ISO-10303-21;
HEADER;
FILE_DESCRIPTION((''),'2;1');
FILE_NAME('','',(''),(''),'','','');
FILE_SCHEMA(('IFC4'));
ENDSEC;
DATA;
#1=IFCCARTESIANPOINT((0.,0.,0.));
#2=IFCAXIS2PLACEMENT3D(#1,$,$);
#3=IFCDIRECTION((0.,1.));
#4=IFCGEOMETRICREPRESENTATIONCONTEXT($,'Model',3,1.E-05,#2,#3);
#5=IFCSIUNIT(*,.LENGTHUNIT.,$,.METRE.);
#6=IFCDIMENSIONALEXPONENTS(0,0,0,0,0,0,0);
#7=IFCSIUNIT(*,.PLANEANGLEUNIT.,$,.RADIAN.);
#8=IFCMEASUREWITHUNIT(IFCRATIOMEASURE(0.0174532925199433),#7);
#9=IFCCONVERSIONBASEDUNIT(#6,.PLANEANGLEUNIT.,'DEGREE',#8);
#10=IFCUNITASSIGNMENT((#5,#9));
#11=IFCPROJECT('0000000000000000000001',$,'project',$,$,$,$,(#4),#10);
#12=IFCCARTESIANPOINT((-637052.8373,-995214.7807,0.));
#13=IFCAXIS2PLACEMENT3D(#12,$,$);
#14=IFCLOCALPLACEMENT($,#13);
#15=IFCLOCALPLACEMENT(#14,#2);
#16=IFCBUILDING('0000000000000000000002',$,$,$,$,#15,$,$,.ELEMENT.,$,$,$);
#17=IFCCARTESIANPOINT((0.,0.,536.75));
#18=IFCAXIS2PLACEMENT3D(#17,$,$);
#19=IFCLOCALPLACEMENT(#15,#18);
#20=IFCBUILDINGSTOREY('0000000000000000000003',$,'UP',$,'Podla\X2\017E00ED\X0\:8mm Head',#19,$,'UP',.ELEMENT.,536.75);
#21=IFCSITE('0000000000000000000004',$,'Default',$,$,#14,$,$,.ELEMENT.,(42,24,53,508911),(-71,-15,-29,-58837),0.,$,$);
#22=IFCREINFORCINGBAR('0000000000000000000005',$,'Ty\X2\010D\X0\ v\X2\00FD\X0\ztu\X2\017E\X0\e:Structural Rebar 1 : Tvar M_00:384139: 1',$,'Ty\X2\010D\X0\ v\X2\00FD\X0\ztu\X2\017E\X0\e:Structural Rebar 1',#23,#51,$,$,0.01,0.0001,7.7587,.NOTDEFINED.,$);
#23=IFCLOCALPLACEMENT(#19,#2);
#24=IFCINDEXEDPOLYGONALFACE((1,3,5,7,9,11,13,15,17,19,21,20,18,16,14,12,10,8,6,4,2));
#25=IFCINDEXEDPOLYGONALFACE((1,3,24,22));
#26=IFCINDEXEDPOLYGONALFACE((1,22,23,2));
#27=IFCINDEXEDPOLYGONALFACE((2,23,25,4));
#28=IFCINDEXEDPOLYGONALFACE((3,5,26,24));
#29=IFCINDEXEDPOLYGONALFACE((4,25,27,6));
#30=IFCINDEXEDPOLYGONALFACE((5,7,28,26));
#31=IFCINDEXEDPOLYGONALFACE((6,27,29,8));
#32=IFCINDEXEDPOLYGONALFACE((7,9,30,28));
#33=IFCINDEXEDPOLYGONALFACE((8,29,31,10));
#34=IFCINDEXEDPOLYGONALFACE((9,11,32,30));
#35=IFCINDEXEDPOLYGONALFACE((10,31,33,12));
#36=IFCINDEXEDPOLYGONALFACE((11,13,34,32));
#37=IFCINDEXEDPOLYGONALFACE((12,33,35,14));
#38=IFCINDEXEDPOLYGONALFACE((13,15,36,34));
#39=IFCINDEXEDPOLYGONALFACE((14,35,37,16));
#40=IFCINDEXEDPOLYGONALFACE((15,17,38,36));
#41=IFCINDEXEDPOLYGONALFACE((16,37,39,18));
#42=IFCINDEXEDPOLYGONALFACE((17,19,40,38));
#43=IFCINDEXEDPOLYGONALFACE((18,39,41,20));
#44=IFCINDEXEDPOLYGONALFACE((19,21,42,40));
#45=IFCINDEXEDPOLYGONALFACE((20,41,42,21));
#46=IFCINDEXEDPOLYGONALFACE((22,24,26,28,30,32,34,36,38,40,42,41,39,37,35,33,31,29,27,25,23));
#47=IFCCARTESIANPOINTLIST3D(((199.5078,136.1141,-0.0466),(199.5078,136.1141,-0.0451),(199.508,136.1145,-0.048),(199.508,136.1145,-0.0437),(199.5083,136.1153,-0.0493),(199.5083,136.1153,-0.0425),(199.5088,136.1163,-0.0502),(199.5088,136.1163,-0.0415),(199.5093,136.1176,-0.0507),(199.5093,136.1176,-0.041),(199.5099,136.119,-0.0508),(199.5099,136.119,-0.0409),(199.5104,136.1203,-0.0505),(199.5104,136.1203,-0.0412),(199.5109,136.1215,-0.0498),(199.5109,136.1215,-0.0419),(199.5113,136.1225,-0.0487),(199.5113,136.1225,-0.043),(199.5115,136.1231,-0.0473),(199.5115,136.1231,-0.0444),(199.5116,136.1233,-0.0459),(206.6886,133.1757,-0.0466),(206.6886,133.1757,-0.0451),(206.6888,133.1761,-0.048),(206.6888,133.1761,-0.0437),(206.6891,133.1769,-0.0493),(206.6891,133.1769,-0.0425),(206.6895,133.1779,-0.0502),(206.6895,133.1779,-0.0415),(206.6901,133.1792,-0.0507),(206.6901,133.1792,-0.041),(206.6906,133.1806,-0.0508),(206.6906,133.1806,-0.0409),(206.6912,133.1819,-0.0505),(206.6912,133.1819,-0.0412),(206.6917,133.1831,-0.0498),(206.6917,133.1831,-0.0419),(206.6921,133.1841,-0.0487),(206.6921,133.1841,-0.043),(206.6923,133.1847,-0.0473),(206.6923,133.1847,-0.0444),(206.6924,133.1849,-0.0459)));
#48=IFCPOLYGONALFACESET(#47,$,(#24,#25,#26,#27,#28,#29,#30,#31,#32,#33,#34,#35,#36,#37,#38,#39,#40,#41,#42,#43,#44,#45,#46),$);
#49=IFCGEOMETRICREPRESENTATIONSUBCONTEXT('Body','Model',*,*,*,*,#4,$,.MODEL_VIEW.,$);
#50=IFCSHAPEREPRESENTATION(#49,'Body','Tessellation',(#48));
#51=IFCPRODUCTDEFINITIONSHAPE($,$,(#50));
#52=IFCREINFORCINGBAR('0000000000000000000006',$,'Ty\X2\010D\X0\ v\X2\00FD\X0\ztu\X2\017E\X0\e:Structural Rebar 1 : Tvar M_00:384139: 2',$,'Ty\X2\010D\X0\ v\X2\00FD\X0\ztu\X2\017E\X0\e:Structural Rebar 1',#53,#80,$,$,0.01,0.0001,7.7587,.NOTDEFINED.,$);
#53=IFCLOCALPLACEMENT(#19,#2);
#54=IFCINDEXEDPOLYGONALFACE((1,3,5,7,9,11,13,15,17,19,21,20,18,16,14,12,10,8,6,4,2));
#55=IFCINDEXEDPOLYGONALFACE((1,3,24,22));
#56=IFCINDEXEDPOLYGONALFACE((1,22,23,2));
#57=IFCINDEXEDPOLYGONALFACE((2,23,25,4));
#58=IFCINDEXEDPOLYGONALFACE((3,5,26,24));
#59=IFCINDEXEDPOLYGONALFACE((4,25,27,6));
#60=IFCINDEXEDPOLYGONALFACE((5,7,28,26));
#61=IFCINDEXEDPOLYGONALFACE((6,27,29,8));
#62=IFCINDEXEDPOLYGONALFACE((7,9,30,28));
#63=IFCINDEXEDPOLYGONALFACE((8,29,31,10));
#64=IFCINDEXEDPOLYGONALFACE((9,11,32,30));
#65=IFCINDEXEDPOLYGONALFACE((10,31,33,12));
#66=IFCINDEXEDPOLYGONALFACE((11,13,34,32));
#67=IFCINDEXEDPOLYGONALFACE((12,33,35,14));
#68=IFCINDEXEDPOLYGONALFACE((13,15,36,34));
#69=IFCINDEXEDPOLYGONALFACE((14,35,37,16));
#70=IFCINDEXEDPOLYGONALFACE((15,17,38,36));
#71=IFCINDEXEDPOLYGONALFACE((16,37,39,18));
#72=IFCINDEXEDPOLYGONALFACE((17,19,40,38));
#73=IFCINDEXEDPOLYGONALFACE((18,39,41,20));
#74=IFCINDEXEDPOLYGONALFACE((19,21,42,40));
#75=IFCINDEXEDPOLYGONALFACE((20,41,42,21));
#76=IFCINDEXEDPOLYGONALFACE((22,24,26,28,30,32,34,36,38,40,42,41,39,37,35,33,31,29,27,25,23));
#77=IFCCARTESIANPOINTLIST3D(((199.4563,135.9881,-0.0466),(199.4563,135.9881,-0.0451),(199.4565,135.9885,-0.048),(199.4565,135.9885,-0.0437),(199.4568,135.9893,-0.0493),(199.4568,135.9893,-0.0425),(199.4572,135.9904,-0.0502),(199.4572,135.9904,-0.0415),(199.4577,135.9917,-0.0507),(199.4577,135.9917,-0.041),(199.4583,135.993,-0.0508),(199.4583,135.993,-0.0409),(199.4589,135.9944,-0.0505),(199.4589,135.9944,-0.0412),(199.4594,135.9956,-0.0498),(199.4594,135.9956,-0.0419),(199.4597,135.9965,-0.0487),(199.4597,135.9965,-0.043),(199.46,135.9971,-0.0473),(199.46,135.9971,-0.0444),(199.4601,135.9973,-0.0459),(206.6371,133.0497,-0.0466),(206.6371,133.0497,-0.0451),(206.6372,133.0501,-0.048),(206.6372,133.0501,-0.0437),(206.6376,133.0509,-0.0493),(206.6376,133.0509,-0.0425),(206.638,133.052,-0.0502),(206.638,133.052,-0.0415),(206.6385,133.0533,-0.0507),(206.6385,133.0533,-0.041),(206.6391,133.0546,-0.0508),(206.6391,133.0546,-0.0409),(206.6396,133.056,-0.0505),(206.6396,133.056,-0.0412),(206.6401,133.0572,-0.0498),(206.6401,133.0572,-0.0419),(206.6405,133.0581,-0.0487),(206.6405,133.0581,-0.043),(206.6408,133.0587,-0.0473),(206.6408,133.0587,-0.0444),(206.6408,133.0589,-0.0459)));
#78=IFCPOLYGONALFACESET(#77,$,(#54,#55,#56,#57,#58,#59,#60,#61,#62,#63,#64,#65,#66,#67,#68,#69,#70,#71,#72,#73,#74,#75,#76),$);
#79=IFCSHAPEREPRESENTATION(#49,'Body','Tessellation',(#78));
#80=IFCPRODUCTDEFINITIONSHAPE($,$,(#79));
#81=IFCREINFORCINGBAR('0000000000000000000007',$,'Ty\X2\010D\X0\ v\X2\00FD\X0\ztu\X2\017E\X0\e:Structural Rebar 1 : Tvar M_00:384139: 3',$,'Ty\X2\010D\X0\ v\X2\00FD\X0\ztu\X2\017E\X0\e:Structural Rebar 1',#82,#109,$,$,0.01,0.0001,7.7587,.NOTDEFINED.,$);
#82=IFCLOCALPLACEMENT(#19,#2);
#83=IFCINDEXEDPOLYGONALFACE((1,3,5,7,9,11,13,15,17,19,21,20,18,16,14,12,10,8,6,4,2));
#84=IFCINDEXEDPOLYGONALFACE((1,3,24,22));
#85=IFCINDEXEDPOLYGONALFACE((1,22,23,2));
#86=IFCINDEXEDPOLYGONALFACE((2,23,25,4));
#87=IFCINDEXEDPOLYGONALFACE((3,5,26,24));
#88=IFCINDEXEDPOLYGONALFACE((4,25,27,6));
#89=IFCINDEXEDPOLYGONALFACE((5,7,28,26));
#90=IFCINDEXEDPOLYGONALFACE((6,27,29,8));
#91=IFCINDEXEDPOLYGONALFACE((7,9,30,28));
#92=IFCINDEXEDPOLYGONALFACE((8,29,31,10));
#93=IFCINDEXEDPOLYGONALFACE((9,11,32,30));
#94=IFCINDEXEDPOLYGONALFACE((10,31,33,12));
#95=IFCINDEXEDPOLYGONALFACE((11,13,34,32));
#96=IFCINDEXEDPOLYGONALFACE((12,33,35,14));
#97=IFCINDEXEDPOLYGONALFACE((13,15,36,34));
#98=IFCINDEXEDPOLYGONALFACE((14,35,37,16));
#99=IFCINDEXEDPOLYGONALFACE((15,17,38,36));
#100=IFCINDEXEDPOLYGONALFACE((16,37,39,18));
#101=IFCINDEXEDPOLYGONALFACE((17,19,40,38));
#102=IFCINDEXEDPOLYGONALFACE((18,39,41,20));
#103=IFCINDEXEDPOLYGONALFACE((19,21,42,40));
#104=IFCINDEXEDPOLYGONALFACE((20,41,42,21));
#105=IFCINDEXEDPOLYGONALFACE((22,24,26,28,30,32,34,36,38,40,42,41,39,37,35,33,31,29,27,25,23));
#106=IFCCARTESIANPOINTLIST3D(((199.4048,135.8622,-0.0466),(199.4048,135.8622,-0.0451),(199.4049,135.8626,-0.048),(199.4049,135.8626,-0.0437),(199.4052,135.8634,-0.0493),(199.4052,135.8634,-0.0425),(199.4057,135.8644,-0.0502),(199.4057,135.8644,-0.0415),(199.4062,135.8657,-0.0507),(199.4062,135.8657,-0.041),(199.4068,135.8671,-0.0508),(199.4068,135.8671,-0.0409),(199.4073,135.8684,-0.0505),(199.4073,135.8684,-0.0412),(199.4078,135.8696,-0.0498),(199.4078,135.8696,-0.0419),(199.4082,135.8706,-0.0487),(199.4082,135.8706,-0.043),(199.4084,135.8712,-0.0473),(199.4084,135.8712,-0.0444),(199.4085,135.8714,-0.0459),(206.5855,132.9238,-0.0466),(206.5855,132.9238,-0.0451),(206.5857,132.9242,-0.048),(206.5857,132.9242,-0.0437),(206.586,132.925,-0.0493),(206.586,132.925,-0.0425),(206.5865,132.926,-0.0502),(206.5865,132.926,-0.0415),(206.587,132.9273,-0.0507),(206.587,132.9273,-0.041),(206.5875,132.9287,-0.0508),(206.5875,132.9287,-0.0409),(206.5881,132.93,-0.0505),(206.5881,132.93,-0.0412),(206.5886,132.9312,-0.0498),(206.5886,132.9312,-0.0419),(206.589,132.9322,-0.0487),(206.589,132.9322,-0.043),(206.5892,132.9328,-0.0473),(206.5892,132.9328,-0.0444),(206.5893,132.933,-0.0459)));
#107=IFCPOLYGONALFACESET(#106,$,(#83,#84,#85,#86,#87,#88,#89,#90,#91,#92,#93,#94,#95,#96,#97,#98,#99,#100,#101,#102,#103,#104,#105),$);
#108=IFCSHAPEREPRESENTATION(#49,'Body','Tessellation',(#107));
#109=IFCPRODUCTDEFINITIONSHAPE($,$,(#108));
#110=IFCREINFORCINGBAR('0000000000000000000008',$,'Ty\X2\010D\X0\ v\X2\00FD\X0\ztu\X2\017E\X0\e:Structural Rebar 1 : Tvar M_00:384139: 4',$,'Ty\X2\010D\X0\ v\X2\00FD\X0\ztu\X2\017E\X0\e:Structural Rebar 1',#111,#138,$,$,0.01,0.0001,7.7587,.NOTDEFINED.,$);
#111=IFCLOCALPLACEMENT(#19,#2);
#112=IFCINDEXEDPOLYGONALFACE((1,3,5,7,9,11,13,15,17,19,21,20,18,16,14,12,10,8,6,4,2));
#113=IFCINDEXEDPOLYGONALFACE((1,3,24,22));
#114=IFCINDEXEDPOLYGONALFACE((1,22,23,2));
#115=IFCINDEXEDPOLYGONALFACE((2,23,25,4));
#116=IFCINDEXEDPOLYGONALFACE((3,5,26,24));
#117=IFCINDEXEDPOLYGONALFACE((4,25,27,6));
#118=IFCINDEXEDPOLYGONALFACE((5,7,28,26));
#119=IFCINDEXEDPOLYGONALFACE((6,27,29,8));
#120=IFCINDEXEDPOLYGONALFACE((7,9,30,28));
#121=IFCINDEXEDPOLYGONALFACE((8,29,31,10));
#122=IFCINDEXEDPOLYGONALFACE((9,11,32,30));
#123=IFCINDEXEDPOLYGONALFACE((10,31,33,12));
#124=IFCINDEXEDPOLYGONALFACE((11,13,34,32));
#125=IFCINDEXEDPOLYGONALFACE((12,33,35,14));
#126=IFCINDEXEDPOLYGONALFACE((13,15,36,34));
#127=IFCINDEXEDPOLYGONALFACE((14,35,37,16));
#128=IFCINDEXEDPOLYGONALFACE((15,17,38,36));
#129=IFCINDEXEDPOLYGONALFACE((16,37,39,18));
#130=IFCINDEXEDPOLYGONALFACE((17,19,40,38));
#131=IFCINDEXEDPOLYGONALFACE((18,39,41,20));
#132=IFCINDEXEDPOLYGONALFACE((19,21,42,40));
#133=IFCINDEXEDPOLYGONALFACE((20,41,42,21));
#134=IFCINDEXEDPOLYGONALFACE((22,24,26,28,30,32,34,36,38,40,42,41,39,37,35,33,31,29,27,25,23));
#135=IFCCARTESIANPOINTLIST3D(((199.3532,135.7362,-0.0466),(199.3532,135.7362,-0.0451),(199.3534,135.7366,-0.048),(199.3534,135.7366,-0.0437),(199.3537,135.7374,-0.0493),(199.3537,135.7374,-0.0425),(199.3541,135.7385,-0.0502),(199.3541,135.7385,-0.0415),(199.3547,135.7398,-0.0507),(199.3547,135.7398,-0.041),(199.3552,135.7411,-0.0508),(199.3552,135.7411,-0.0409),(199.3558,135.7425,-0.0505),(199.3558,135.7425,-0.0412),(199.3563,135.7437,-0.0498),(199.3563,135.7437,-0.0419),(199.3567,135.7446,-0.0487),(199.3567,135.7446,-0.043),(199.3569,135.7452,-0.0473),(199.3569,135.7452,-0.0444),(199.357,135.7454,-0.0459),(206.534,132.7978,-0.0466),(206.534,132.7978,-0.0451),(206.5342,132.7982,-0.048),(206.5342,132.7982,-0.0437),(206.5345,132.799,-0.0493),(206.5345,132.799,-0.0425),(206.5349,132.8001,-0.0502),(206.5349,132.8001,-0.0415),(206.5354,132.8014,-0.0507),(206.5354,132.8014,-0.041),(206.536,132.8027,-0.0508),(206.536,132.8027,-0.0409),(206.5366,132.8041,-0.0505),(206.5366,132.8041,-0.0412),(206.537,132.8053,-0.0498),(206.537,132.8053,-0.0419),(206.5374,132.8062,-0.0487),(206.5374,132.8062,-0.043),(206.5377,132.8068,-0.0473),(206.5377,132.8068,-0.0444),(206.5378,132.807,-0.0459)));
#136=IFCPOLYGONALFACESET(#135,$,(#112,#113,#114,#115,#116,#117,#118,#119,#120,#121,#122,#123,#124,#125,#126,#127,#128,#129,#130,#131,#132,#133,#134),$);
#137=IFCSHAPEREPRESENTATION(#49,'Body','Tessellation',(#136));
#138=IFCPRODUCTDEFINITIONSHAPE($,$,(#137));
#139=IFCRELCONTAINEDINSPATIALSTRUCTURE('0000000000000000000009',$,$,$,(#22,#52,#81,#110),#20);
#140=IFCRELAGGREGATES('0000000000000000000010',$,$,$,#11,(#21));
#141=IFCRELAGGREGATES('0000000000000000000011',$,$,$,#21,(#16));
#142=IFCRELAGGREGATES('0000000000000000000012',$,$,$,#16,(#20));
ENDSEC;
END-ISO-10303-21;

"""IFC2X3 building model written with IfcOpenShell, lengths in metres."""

from ifc_helpers import new_model, entity, si_unit, converted_unit, direction, frame, origin, place, context, subcontext, project, spatial, element, save


model = new_model("IFC2X3")

# Units and contexts
model_context = context("Model", 3, precision=1e-05, world=origin(), true_north=direction((0.0, 1.0)))
body_context = subcontext(model_context, "Body", "Model", "MODEL_VIEW")
ifc_project = project(units=[si_unit("LENGTHUNIT", "METRE"), converted_unit("PLANEANGLEUNIT", "DEGREE", entity("IfcRatioMeasure", 0.0174532925199433), si_unit("PLANEANGLEUNIT", "RADIAN"), dimensions=[0, 0, 0, 0, 0, 0, 0])], contexts=[model_context])

# Site, building, storey
site_placement = place(None, frame((-637052.8373, -995214.7807, 0.0)))
site = spatial("IfcSite", under=ifc_project, at=site_placement, Name="Default", CompositionType="ELEMENT", RefLatitude=(42, 24, 53, 508911), RefLongitude=(-71, -15, -29, -58837), RefElevation=0.0)
building_placement = place(site_placement, origin())
building = spatial("IfcBuilding", under=site, at=building_placement, CompositionType="ELEMENT")
storey_placement = place(building_placement, frame((0.0, 0.0, 536.75)))
storey = spatial("IfcBuildingStorey", under=building, at=storey_placement, Name="UP", ObjectType="Podlaží:8mm Head", LongName="UP", CompositionType="ELEMENT", Elevation=536.75)

# Reinforcing bars
reinforcing_bar_1_placement = place(storey_placement, origin())
element("IfcReinforcingBar", 1, at=reinforcing_bar_1_placement, inside=storey, Name="Tyč výztuže:Structural Rebar 1 : Tvar M_00:384139: 1", ObjectType="Tyč výztuže:Structural Rebar 1", BarLength=7.7587, BarRole="NOTDEFINED", CrossSectionArea=0.0001, NominalDiameter=0.01, context=body_context, shape_type="AdvancedSweptSolid", body=[
    entity("IfcSweptDiskSolid", entity("IfcCompositeCurve", [entity("IfcCompositeCurveSegment", "CONTINUOUS", True, entity("IfcPolyline", [entity("IfcCartesianPoint", [-206.6905, -133.1803, 0.0459]), entity("IfcCartesianPoint", [-199.5097, -136.1187, 0.0459])]))], False), 0.005, None, 0.0, 1.0),
])
reinforcing_bar_2_placement = place(storey_placement, origin())
element("IfcReinforcingBar", 2, at=reinforcing_bar_2_placement, inside=storey, Name="Tyč výztuže:Structural Rebar 1 : Tvar M_00:384139: 2", ObjectType="Tyč výztuže:Structural Rebar 1", BarLength=7.7587, BarRole="NOTDEFINED", CrossSectionArea=0.0001, NominalDiameter=0.01, context=body_context, shape_type="AdvancedSweptSolid", body=[
    entity("IfcSweptDiskSolid", entity("IfcCompositeCurve", [entity("IfcCompositeCurveSegment", "CONTINUOUS", True, entity("IfcPolyline", [entity("IfcCartesianPoint", [-206.6389, -133.0543, 0.0459]), entity("IfcCartesianPoint", [-199.4582, -135.9927, 0.0459])]))], False), 0.005, None, 0.0, 1.0),
])
reinforcing_bar_3_placement = place(storey_placement, origin())
element("IfcReinforcingBar", 3, at=reinforcing_bar_3_placement, inside=storey, Name="Tyč výztuže:Structural Rebar 1 : Tvar M_00:384139: 3", ObjectType="Tyč výztuže:Structural Rebar 1", BarLength=7.7587, BarRole="NOTDEFINED", CrossSectionArea=0.0001, NominalDiameter=0.01, context=body_context, shape_type="AdvancedSweptSolid", body=[
    entity("IfcSweptDiskSolid", entity("IfcCompositeCurve", [entity("IfcCompositeCurveSegment", "CONTINUOUS", True, entity("IfcPolyline", [entity("IfcCartesianPoint", [-206.5874, -132.9283, 0.0459]), entity("IfcCartesianPoint", [-199.4066, -135.8667, 0.0459])]))], False), 0.005, None, 0.0, 1.0),
])
reinforcing_bar_4_placement = place(storey_placement, origin())
element("IfcReinforcingBar", 4, at=reinforcing_bar_4_placement, inside=storey, Name="Tyč výztuže:Structural Rebar 1 : Tvar M_00:384139: 4", ObjectType="Tyč výztuže:Structural Rebar 1", BarLength=7.7587, BarRole="NOTDEFINED", CrossSectionArea=0.0001, NominalDiameter=0.01, context=body_context, shape_type="AdvancedSweptSolid", body=[
    entity("IfcSweptDiskSolid", entity("IfcCompositeCurve", [entity("IfcCompositeCurveSegment", "CONTINUOUS", True, entity("IfcPolyline", [entity("IfcCartesianPoint", [-206.5359, -132.8024, 0.0459]), entity("IfcCartesianPoint", [-199.3551, -135.7408, 0.0459])]))], False), 0.005, None, 0.0, 1.0),
])

save(model, "model.ifc")
